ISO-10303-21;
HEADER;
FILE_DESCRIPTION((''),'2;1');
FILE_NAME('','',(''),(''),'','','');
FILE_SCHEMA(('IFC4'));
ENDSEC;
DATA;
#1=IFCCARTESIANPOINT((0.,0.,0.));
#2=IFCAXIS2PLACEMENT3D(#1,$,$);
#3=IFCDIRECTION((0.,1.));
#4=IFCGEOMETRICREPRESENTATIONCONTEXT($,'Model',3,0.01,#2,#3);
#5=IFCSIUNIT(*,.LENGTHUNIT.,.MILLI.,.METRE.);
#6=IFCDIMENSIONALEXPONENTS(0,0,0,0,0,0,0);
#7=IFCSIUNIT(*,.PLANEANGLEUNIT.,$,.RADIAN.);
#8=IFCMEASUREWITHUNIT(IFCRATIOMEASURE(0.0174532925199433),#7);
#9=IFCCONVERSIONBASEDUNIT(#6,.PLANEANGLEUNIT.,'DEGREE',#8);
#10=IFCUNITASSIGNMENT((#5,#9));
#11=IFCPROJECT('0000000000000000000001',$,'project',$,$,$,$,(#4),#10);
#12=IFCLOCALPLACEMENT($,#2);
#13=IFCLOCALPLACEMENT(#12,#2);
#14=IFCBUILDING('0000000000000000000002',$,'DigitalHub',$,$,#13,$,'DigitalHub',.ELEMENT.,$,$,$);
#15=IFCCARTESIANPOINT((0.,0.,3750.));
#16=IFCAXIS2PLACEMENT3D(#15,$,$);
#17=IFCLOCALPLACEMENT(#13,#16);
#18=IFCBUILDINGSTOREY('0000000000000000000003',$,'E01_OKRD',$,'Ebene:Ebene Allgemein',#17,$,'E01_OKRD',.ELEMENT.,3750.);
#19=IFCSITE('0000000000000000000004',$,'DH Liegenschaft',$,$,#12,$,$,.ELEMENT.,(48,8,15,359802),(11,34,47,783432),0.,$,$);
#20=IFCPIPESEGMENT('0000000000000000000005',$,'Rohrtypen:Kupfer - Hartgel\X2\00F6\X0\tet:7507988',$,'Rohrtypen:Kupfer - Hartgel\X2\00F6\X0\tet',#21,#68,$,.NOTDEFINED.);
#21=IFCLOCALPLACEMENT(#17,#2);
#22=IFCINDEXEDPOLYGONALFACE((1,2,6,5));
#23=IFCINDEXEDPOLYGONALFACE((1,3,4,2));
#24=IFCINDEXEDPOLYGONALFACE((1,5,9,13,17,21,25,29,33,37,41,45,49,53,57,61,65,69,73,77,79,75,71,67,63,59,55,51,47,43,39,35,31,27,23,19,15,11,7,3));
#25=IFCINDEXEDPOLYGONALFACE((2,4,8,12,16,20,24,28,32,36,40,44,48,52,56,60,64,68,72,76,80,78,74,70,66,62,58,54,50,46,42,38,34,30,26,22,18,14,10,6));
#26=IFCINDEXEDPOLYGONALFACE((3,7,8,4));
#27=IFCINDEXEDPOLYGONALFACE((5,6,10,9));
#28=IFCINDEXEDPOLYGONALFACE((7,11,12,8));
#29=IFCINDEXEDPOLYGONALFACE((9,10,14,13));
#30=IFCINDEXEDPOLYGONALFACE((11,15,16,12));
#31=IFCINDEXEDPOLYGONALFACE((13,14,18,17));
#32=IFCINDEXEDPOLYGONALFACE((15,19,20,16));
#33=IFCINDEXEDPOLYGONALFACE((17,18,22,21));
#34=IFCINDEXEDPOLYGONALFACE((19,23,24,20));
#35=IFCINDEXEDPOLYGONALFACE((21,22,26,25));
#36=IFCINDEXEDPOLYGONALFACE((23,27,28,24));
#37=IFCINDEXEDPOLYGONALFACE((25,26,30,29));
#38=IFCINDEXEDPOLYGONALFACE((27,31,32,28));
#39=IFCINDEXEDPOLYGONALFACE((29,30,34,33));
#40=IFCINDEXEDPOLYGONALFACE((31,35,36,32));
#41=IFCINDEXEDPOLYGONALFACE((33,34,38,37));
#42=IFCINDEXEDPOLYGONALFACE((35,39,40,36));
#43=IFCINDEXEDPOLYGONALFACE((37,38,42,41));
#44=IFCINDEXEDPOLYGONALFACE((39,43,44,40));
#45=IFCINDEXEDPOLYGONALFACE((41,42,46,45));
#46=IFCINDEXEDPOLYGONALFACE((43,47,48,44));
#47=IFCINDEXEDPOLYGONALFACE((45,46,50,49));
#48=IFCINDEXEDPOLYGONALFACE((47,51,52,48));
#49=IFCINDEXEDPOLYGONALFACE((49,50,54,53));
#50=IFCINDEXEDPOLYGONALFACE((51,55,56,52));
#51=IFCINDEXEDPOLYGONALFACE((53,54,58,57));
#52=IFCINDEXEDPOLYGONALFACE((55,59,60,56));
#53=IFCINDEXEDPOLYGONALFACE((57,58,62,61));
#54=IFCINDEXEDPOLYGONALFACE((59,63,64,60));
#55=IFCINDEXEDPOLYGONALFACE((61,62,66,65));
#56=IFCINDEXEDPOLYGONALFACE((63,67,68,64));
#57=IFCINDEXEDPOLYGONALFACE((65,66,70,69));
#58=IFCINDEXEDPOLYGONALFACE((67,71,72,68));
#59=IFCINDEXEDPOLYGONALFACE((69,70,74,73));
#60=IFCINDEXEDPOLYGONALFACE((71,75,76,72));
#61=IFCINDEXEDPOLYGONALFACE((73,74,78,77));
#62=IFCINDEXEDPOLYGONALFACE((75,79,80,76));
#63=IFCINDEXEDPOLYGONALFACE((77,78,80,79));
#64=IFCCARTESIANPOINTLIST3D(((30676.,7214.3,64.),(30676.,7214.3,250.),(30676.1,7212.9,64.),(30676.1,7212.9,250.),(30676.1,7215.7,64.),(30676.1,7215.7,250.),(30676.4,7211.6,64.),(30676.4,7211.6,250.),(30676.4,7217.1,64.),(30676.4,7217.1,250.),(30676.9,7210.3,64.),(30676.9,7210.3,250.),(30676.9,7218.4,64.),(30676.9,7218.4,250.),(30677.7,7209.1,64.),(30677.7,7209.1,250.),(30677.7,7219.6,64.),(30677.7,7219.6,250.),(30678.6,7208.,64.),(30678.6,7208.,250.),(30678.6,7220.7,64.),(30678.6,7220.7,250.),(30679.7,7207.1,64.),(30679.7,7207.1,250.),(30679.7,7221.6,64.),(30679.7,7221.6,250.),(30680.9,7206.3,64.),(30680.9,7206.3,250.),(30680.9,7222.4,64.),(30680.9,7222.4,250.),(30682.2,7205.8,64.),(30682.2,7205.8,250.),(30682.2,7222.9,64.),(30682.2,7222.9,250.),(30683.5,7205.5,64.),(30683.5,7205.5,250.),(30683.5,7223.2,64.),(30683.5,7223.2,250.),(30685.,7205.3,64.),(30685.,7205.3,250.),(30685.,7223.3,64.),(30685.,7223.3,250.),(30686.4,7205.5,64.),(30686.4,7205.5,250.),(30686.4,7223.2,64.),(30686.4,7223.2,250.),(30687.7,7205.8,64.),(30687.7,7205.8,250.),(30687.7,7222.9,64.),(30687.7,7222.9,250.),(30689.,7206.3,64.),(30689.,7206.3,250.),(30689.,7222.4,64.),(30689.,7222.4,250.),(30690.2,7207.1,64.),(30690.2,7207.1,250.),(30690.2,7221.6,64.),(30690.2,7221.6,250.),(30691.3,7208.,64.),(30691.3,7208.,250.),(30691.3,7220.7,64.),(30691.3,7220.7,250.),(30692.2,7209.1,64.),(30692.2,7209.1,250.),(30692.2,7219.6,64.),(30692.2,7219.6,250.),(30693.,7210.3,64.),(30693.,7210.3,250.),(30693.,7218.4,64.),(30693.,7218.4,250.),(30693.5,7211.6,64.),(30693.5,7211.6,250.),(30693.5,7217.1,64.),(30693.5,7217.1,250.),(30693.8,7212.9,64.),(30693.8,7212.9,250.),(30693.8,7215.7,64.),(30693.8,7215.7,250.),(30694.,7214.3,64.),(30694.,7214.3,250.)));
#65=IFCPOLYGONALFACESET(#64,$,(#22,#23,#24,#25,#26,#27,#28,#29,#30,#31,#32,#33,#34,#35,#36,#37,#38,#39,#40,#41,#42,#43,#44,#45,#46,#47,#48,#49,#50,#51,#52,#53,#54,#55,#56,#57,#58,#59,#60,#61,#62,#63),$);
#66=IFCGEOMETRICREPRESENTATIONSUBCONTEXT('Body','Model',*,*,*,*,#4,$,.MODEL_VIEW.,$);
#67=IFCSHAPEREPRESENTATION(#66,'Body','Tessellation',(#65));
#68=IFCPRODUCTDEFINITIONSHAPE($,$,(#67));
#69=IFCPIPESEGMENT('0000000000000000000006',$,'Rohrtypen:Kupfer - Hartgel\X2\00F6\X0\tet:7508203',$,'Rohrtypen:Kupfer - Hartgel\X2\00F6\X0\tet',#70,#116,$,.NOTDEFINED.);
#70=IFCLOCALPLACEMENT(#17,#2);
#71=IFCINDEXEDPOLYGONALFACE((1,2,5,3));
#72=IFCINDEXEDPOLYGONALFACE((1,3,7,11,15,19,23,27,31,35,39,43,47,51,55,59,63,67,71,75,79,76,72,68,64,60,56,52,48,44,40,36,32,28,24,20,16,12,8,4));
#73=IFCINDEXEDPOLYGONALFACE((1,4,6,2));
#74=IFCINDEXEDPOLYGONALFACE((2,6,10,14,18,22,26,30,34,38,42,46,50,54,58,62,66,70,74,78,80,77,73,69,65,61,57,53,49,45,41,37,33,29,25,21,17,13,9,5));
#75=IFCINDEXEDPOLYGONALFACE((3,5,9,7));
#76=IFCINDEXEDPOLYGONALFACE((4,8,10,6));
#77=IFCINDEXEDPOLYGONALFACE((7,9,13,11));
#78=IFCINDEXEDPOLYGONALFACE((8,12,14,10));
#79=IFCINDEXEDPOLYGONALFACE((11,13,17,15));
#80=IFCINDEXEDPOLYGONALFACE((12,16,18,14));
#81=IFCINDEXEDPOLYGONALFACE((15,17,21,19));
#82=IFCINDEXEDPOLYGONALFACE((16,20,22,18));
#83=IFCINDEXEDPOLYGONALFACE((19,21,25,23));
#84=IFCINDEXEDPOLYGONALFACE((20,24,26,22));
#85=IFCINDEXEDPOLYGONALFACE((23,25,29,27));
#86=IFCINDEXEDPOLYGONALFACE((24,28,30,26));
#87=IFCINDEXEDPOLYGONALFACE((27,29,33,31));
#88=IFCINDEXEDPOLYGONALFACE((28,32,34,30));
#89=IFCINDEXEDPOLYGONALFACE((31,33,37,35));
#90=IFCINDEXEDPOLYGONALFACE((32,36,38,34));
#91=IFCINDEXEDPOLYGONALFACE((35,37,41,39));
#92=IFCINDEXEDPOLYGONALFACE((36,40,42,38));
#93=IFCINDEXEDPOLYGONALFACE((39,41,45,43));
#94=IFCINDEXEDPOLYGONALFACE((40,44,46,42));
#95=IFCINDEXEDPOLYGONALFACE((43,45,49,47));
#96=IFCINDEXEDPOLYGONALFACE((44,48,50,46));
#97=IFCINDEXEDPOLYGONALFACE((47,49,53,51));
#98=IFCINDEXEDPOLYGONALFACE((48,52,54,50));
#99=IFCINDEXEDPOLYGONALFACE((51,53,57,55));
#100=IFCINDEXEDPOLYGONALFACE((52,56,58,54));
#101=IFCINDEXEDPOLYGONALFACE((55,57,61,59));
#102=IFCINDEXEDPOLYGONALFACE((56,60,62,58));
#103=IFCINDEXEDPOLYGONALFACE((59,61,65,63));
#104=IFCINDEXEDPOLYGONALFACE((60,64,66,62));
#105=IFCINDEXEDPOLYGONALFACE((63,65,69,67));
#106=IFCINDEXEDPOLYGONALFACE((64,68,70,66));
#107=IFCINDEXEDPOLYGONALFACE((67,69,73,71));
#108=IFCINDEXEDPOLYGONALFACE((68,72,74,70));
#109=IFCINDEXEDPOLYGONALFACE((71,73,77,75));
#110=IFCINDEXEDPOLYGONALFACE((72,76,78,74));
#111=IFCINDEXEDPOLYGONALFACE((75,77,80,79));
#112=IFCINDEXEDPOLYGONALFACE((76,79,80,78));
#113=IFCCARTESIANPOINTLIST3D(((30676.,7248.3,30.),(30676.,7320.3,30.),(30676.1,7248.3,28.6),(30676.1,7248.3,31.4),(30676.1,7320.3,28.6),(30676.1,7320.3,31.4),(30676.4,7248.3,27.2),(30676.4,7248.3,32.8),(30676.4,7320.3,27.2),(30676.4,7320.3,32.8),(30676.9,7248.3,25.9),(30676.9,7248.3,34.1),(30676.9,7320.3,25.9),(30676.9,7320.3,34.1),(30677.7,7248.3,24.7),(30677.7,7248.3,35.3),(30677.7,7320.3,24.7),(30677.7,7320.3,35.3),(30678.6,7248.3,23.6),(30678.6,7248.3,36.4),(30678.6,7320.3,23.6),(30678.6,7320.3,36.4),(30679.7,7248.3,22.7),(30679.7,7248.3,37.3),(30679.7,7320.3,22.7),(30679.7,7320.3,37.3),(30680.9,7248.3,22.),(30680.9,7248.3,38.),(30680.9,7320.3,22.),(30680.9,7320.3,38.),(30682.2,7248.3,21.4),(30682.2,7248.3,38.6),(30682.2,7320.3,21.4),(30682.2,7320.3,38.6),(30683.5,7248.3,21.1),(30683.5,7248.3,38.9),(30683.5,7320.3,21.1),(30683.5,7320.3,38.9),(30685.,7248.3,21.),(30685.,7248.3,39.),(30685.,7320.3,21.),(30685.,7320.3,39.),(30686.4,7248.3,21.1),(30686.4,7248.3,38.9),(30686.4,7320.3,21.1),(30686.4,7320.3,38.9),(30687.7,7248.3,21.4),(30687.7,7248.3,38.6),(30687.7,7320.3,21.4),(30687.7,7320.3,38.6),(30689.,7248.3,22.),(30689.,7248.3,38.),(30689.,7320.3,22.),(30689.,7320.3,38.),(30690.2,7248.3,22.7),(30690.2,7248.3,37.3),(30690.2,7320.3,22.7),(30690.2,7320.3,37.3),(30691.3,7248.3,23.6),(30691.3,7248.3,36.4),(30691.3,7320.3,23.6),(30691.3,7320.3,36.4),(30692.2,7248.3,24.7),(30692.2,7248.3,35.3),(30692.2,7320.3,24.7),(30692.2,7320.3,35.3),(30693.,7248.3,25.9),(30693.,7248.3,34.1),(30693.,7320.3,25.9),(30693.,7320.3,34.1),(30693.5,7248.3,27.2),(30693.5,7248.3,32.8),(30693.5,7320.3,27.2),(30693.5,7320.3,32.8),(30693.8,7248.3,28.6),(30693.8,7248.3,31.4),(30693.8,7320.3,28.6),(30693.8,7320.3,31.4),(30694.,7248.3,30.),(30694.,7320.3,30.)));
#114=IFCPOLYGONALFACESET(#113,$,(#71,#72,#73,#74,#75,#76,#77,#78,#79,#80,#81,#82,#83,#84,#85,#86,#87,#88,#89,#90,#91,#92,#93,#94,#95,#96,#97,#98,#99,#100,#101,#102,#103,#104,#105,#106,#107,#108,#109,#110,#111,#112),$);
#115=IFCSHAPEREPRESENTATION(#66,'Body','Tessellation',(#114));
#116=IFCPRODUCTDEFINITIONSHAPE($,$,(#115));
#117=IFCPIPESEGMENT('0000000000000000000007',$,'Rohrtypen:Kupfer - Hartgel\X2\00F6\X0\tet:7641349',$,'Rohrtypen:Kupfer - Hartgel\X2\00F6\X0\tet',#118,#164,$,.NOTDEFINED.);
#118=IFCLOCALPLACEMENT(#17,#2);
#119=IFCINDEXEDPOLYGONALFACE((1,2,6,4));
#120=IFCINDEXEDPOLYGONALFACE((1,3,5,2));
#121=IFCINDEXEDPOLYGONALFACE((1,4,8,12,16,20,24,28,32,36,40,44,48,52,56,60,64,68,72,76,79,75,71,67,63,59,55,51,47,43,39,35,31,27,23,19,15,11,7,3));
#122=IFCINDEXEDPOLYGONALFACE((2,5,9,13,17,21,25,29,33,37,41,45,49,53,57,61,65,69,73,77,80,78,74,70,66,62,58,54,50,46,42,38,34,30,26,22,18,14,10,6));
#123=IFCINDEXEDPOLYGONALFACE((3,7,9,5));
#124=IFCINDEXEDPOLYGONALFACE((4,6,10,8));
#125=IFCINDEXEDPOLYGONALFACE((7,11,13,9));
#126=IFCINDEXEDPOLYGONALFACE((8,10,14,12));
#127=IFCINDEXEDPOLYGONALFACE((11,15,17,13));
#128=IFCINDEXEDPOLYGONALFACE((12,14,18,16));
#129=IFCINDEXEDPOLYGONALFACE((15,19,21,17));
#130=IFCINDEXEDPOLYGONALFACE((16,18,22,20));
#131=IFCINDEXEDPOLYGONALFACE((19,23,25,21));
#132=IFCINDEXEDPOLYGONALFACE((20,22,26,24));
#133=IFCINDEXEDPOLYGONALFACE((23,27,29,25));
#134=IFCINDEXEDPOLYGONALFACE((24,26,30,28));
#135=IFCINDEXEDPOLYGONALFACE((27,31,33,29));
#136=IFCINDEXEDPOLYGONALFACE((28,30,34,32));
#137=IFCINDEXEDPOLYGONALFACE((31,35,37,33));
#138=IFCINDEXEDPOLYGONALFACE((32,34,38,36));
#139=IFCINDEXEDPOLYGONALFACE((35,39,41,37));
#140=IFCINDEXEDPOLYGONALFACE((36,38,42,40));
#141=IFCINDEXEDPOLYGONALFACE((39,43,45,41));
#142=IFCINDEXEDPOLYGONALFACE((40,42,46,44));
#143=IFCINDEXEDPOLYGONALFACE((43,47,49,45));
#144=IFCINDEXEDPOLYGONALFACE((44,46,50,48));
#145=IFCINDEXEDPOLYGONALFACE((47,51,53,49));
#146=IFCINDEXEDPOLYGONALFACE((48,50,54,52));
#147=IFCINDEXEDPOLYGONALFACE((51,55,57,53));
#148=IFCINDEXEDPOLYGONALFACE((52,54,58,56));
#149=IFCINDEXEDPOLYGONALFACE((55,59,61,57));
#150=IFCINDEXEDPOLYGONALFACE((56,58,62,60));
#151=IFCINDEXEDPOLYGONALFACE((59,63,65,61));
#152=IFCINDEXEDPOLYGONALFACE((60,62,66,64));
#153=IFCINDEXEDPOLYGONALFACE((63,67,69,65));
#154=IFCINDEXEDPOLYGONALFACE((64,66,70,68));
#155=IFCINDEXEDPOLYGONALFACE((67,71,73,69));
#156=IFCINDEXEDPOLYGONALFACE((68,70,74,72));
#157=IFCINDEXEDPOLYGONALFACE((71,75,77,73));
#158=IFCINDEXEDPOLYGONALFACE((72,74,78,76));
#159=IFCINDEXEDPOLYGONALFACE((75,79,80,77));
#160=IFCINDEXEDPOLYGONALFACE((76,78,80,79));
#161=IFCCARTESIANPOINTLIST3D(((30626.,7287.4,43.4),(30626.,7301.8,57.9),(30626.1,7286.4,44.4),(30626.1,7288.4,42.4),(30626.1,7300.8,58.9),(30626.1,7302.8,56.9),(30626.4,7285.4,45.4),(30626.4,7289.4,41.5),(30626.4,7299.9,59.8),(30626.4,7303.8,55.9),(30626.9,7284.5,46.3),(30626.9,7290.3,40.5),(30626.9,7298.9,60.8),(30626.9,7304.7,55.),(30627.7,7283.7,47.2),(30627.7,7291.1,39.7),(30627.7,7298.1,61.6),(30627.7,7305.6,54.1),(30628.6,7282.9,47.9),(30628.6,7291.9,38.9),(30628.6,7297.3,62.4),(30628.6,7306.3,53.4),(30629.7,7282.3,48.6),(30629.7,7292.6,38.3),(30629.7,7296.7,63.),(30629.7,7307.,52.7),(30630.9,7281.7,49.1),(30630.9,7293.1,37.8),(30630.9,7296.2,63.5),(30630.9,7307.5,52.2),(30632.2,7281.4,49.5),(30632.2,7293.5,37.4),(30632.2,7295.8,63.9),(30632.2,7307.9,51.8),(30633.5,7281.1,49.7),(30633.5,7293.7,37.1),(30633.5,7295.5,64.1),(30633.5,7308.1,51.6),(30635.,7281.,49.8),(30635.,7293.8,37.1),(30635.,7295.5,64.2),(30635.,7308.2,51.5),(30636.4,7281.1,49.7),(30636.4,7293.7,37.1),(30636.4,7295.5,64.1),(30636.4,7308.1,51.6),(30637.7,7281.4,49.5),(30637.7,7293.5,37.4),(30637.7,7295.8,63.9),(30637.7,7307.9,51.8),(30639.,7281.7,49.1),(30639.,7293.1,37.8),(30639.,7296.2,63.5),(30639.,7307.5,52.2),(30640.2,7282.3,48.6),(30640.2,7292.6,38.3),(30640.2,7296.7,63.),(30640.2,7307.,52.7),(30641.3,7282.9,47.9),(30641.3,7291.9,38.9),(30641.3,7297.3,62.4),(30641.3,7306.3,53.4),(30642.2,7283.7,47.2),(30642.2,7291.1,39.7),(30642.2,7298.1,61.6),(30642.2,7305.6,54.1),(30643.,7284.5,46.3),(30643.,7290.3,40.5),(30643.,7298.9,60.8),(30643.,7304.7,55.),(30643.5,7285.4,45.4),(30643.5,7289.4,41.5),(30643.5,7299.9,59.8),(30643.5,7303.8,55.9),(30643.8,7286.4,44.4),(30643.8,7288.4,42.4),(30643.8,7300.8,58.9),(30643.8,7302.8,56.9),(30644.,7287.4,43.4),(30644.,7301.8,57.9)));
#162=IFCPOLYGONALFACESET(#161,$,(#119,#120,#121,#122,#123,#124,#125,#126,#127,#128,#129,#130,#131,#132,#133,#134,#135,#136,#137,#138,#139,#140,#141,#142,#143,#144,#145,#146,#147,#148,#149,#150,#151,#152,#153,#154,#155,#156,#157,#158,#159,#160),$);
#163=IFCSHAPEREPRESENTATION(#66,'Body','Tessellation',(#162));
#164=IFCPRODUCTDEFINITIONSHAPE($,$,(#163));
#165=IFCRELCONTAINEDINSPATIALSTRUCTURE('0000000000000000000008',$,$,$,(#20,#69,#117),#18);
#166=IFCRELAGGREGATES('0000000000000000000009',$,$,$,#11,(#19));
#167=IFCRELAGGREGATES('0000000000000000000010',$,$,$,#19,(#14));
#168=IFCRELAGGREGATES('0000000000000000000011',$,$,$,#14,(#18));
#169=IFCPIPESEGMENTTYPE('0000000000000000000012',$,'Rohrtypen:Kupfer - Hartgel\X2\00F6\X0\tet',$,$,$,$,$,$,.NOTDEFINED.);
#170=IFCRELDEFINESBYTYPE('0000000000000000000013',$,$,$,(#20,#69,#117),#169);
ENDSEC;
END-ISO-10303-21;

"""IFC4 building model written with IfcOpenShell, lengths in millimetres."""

from ifc_helpers import new_model, entity, si_unit, converted_unit, direction, frame, origin, place, context, subcontext, project, spatial, indexed_curve, outline, extrude, type_object, element, save


model = new_model("IFC4")

# Units and contexts
model_context = context("Model", 3, precision=0.01, world=origin(), true_north=direction((0.0, 1.0)))
body_context = subcontext(model_context, "Body", "Model", "MODEL_VIEW")
ifc_project = project(units=[si_unit("LENGTHUNIT", "METRE", prefix="MILLI"), converted_unit("PLANEANGLEUNIT", "DEGREE", entity("IfcRatioMeasure", 0.0174532925199433), si_unit("PLANEANGLEUNIT", "RADIAN"), dimensions=[0, 0, 0, 0, 0, 0, 0])], contexts=[model_context])

# Site, building, storey
site_placement = place(None, origin())
site = spatial("IfcSite", under=ifc_project, at=site_placement, Name="DH Liegenschaft", CompositionType="ELEMENT", RefLatitude=(48, 8, 15, 359802), RefLongitude=(11, 34, 47, 783432), RefElevation=0.0)
building_placement = place(site_placement, origin())
building = spatial("IfcBuilding", under=site, at=building_placement, Name="DigitalHub", LongName="DigitalHub", CompositionType="ELEMENT")
storey_placement = place(building_placement, frame((0.0, 0.0, 3750.0)))
storey = spatial("IfcBuildingStorey", under=building, at=storey_placement, Name="E01_OKRD", ObjectType="Ebene:Ebene Allgemein", LongName="E01_OKRD", CompositionType="ELEMENT", Elevation=3750.0)

# Pipe segments
pipe_segment_type = type_object("IfcPipeSegmentType", Name="Rohrtypen:Kupfer - Hartgelötet", PredefinedType="NOTDEFINED")
pipe_segment_1_placement = place(storey_placement, frame((30674.4, 7203.7, 64.0)))
element("IfcPipeSegment", 1, at=pipe_segment_1_placement, inside=storey, type_object=pipe_segment_type, Name="Rohrtypen:Kupfer - Hartgelötet:7507988", ObjectType="Rohrtypen:Kupfer - Hartgelötet", PredefinedType="NOTDEFINED", context=body_context, shape_type="SweptSolid", body=[
    extrude(outline(indexed_curve([(9.0, 0.0), (8.9, 1.4), (8.6, 2.8), (8.0, 4.1), (7.3, 5.3), (6.4, 6.4), (5.3, 7.3), (4.1, 8.0), (2.8, 8.6), (1.4, 8.9), (0.0, 9.0), (-1.4, 8.9), (-2.8, 8.6), (-4.1, 8.0), (-5.3, 7.3), (-6.4, 6.4), (-7.3, 5.3), (-8.0, 4.1), (-8.6, 2.8), (-8.9, 1.4), (-9.0, 0.0), (-8.9, -1.4), (-8.6, -2.8), (-8.0, -4.1), (-7.3, -5.3), (-6.4, -6.4), (-5.3, -7.3), (-4.1, -8.0), (-2.8, -8.6), (-1.4, -8.9), (0.0, -9.0), (1.4, -8.9), (2.8, -8.6), (4.1, -8.0), (5.3, -7.3), (6.4, -6.4), (7.3, -5.3), (8.0, -4.1), (8.6, -2.8), (8.9, -1.4), (9.0, 0.0)], self_intersect=False)), frame((10.6, 10.6, 0.0)), (0.0, 0.0, 1.0), 186.0),
])
pipe_segment_2_placement = place(storey_placement, frame((30674.4, 7248.3, 19.4)))
element("IfcPipeSegment", 2, at=pipe_segment_2_placement, inside=storey, type_object=pipe_segment_type, Name="Rohrtypen:Kupfer - Hartgelötet:7508203", ObjectType="Rohrtypen:Kupfer - Hartgelötet", PredefinedType="NOTDEFINED", context=body_context, shape_type="SweptSolid", body=[
    extrude(outline(indexed_curve([(9.0, 0.0), (8.9, 1.4), (8.6, 2.8), (8.0, 4.1), (7.3, 5.3), (6.4, 6.4), (5.3, 7.3), (4.1, 8.0), (2.8, 8.6), (1.4, 8.9), (0.0, 9.0), (-1.4, 8.9), (-2.8, 8.6), (-4.1, 8.0), (-5.3, 7.3), (-6.4, 6.4), (-7.3, 5.3), (-8.0, 4.1), (-8.6, 2.8), (-8.9, 1.4), (-9.0, 0.0), (-8.9, -1.4), (-8.6, -2.8), (-8.0, -4.1), (-7.3, -5.3), (-6.4, -6.4), (-5.3, -7.3), (-4.1, -8.0), (-2.8, -8.6), (-1.4, -8.9), (0.0, -9.0), (1.4, -8.9), (2.8, -8.6), (4.1, -8.0), (5.3, -7.3), (6.4, -6.4), (7.3, -5.3), (8.0, -4.1), (8.6, -2.8), (8.9, -1.4), (9.0, 0.0)], self_intersect=False)), frame((10.6, 0.0, 10.6), z_axis=(0.0, 1.0, 0.0), x_axis=(-1.0, 0.0, 0.0)), (0.0, 0.0, 1.0), 71.9),
])
pipe_segment_3_placement = place(storey_placement, frame((30624.4, 7279.4, 35.5)))
element("IfcPipeSegment", 3, at=pipe_segment_3_placement, inside=storey, type_object=pipe_segment_type, Name="Rohrtypen:Kupfer - Hartgelötet:7641349", ObjectType="Rohrtypen:Kupfer - Hartgelötet", PredefinedType="NOTDEFINED", context=body_context, shape_type="SweptSolid", body=[
    extrude(outline(indexed_curve([(9.0, 0.0), (8.9, 1.4), (8.6, 2.8), (8.0, 4.1), (7.3, 5.3), (6.4, 6.4), (5.3, 7.3), (4.1, 8.0), (2.8, 8.6), (1.4, 8.9), (0.0, 9.0), (-1.4, 8.9), (-2.8, 8.6), (-4.1, 8.0), (-5.3, 7.3), (-6.4, 6.4), (-7.3, 5.3), (-8.0, 4.1), (-8.6, 2.8), (-8.9, 1.4), (-9.0, 0.0), (-8.9, -1.4), (-8.6, -2.8), (-8.0, -4.1), (-7.3, -5.3), (-6.4, -6.4), (-5.3, -7.3), (-4.1, -8.0), (-2.8, -8.6), (-1.4, -8.9), (0.0, -9.0), (1.4, -8.9), (2.8, -8.6), (4.1, -8.0), (5.3, -7.3), (6.4, -6.4), (7.3, -5.3), (8.0, -4.1), (8.6, -2.8), (8.9, -1.4), (9.0, 0.0)], self_intersect=False)), frame((10.6, 8.0, 8.0), z_axis=(0.0, 0.707107, 0.707107), x_axis=(1.0, 0.0, 0.0)), (0.0, 0.0, 1.0), 20.4),
])

save(model, "model.ifc")
